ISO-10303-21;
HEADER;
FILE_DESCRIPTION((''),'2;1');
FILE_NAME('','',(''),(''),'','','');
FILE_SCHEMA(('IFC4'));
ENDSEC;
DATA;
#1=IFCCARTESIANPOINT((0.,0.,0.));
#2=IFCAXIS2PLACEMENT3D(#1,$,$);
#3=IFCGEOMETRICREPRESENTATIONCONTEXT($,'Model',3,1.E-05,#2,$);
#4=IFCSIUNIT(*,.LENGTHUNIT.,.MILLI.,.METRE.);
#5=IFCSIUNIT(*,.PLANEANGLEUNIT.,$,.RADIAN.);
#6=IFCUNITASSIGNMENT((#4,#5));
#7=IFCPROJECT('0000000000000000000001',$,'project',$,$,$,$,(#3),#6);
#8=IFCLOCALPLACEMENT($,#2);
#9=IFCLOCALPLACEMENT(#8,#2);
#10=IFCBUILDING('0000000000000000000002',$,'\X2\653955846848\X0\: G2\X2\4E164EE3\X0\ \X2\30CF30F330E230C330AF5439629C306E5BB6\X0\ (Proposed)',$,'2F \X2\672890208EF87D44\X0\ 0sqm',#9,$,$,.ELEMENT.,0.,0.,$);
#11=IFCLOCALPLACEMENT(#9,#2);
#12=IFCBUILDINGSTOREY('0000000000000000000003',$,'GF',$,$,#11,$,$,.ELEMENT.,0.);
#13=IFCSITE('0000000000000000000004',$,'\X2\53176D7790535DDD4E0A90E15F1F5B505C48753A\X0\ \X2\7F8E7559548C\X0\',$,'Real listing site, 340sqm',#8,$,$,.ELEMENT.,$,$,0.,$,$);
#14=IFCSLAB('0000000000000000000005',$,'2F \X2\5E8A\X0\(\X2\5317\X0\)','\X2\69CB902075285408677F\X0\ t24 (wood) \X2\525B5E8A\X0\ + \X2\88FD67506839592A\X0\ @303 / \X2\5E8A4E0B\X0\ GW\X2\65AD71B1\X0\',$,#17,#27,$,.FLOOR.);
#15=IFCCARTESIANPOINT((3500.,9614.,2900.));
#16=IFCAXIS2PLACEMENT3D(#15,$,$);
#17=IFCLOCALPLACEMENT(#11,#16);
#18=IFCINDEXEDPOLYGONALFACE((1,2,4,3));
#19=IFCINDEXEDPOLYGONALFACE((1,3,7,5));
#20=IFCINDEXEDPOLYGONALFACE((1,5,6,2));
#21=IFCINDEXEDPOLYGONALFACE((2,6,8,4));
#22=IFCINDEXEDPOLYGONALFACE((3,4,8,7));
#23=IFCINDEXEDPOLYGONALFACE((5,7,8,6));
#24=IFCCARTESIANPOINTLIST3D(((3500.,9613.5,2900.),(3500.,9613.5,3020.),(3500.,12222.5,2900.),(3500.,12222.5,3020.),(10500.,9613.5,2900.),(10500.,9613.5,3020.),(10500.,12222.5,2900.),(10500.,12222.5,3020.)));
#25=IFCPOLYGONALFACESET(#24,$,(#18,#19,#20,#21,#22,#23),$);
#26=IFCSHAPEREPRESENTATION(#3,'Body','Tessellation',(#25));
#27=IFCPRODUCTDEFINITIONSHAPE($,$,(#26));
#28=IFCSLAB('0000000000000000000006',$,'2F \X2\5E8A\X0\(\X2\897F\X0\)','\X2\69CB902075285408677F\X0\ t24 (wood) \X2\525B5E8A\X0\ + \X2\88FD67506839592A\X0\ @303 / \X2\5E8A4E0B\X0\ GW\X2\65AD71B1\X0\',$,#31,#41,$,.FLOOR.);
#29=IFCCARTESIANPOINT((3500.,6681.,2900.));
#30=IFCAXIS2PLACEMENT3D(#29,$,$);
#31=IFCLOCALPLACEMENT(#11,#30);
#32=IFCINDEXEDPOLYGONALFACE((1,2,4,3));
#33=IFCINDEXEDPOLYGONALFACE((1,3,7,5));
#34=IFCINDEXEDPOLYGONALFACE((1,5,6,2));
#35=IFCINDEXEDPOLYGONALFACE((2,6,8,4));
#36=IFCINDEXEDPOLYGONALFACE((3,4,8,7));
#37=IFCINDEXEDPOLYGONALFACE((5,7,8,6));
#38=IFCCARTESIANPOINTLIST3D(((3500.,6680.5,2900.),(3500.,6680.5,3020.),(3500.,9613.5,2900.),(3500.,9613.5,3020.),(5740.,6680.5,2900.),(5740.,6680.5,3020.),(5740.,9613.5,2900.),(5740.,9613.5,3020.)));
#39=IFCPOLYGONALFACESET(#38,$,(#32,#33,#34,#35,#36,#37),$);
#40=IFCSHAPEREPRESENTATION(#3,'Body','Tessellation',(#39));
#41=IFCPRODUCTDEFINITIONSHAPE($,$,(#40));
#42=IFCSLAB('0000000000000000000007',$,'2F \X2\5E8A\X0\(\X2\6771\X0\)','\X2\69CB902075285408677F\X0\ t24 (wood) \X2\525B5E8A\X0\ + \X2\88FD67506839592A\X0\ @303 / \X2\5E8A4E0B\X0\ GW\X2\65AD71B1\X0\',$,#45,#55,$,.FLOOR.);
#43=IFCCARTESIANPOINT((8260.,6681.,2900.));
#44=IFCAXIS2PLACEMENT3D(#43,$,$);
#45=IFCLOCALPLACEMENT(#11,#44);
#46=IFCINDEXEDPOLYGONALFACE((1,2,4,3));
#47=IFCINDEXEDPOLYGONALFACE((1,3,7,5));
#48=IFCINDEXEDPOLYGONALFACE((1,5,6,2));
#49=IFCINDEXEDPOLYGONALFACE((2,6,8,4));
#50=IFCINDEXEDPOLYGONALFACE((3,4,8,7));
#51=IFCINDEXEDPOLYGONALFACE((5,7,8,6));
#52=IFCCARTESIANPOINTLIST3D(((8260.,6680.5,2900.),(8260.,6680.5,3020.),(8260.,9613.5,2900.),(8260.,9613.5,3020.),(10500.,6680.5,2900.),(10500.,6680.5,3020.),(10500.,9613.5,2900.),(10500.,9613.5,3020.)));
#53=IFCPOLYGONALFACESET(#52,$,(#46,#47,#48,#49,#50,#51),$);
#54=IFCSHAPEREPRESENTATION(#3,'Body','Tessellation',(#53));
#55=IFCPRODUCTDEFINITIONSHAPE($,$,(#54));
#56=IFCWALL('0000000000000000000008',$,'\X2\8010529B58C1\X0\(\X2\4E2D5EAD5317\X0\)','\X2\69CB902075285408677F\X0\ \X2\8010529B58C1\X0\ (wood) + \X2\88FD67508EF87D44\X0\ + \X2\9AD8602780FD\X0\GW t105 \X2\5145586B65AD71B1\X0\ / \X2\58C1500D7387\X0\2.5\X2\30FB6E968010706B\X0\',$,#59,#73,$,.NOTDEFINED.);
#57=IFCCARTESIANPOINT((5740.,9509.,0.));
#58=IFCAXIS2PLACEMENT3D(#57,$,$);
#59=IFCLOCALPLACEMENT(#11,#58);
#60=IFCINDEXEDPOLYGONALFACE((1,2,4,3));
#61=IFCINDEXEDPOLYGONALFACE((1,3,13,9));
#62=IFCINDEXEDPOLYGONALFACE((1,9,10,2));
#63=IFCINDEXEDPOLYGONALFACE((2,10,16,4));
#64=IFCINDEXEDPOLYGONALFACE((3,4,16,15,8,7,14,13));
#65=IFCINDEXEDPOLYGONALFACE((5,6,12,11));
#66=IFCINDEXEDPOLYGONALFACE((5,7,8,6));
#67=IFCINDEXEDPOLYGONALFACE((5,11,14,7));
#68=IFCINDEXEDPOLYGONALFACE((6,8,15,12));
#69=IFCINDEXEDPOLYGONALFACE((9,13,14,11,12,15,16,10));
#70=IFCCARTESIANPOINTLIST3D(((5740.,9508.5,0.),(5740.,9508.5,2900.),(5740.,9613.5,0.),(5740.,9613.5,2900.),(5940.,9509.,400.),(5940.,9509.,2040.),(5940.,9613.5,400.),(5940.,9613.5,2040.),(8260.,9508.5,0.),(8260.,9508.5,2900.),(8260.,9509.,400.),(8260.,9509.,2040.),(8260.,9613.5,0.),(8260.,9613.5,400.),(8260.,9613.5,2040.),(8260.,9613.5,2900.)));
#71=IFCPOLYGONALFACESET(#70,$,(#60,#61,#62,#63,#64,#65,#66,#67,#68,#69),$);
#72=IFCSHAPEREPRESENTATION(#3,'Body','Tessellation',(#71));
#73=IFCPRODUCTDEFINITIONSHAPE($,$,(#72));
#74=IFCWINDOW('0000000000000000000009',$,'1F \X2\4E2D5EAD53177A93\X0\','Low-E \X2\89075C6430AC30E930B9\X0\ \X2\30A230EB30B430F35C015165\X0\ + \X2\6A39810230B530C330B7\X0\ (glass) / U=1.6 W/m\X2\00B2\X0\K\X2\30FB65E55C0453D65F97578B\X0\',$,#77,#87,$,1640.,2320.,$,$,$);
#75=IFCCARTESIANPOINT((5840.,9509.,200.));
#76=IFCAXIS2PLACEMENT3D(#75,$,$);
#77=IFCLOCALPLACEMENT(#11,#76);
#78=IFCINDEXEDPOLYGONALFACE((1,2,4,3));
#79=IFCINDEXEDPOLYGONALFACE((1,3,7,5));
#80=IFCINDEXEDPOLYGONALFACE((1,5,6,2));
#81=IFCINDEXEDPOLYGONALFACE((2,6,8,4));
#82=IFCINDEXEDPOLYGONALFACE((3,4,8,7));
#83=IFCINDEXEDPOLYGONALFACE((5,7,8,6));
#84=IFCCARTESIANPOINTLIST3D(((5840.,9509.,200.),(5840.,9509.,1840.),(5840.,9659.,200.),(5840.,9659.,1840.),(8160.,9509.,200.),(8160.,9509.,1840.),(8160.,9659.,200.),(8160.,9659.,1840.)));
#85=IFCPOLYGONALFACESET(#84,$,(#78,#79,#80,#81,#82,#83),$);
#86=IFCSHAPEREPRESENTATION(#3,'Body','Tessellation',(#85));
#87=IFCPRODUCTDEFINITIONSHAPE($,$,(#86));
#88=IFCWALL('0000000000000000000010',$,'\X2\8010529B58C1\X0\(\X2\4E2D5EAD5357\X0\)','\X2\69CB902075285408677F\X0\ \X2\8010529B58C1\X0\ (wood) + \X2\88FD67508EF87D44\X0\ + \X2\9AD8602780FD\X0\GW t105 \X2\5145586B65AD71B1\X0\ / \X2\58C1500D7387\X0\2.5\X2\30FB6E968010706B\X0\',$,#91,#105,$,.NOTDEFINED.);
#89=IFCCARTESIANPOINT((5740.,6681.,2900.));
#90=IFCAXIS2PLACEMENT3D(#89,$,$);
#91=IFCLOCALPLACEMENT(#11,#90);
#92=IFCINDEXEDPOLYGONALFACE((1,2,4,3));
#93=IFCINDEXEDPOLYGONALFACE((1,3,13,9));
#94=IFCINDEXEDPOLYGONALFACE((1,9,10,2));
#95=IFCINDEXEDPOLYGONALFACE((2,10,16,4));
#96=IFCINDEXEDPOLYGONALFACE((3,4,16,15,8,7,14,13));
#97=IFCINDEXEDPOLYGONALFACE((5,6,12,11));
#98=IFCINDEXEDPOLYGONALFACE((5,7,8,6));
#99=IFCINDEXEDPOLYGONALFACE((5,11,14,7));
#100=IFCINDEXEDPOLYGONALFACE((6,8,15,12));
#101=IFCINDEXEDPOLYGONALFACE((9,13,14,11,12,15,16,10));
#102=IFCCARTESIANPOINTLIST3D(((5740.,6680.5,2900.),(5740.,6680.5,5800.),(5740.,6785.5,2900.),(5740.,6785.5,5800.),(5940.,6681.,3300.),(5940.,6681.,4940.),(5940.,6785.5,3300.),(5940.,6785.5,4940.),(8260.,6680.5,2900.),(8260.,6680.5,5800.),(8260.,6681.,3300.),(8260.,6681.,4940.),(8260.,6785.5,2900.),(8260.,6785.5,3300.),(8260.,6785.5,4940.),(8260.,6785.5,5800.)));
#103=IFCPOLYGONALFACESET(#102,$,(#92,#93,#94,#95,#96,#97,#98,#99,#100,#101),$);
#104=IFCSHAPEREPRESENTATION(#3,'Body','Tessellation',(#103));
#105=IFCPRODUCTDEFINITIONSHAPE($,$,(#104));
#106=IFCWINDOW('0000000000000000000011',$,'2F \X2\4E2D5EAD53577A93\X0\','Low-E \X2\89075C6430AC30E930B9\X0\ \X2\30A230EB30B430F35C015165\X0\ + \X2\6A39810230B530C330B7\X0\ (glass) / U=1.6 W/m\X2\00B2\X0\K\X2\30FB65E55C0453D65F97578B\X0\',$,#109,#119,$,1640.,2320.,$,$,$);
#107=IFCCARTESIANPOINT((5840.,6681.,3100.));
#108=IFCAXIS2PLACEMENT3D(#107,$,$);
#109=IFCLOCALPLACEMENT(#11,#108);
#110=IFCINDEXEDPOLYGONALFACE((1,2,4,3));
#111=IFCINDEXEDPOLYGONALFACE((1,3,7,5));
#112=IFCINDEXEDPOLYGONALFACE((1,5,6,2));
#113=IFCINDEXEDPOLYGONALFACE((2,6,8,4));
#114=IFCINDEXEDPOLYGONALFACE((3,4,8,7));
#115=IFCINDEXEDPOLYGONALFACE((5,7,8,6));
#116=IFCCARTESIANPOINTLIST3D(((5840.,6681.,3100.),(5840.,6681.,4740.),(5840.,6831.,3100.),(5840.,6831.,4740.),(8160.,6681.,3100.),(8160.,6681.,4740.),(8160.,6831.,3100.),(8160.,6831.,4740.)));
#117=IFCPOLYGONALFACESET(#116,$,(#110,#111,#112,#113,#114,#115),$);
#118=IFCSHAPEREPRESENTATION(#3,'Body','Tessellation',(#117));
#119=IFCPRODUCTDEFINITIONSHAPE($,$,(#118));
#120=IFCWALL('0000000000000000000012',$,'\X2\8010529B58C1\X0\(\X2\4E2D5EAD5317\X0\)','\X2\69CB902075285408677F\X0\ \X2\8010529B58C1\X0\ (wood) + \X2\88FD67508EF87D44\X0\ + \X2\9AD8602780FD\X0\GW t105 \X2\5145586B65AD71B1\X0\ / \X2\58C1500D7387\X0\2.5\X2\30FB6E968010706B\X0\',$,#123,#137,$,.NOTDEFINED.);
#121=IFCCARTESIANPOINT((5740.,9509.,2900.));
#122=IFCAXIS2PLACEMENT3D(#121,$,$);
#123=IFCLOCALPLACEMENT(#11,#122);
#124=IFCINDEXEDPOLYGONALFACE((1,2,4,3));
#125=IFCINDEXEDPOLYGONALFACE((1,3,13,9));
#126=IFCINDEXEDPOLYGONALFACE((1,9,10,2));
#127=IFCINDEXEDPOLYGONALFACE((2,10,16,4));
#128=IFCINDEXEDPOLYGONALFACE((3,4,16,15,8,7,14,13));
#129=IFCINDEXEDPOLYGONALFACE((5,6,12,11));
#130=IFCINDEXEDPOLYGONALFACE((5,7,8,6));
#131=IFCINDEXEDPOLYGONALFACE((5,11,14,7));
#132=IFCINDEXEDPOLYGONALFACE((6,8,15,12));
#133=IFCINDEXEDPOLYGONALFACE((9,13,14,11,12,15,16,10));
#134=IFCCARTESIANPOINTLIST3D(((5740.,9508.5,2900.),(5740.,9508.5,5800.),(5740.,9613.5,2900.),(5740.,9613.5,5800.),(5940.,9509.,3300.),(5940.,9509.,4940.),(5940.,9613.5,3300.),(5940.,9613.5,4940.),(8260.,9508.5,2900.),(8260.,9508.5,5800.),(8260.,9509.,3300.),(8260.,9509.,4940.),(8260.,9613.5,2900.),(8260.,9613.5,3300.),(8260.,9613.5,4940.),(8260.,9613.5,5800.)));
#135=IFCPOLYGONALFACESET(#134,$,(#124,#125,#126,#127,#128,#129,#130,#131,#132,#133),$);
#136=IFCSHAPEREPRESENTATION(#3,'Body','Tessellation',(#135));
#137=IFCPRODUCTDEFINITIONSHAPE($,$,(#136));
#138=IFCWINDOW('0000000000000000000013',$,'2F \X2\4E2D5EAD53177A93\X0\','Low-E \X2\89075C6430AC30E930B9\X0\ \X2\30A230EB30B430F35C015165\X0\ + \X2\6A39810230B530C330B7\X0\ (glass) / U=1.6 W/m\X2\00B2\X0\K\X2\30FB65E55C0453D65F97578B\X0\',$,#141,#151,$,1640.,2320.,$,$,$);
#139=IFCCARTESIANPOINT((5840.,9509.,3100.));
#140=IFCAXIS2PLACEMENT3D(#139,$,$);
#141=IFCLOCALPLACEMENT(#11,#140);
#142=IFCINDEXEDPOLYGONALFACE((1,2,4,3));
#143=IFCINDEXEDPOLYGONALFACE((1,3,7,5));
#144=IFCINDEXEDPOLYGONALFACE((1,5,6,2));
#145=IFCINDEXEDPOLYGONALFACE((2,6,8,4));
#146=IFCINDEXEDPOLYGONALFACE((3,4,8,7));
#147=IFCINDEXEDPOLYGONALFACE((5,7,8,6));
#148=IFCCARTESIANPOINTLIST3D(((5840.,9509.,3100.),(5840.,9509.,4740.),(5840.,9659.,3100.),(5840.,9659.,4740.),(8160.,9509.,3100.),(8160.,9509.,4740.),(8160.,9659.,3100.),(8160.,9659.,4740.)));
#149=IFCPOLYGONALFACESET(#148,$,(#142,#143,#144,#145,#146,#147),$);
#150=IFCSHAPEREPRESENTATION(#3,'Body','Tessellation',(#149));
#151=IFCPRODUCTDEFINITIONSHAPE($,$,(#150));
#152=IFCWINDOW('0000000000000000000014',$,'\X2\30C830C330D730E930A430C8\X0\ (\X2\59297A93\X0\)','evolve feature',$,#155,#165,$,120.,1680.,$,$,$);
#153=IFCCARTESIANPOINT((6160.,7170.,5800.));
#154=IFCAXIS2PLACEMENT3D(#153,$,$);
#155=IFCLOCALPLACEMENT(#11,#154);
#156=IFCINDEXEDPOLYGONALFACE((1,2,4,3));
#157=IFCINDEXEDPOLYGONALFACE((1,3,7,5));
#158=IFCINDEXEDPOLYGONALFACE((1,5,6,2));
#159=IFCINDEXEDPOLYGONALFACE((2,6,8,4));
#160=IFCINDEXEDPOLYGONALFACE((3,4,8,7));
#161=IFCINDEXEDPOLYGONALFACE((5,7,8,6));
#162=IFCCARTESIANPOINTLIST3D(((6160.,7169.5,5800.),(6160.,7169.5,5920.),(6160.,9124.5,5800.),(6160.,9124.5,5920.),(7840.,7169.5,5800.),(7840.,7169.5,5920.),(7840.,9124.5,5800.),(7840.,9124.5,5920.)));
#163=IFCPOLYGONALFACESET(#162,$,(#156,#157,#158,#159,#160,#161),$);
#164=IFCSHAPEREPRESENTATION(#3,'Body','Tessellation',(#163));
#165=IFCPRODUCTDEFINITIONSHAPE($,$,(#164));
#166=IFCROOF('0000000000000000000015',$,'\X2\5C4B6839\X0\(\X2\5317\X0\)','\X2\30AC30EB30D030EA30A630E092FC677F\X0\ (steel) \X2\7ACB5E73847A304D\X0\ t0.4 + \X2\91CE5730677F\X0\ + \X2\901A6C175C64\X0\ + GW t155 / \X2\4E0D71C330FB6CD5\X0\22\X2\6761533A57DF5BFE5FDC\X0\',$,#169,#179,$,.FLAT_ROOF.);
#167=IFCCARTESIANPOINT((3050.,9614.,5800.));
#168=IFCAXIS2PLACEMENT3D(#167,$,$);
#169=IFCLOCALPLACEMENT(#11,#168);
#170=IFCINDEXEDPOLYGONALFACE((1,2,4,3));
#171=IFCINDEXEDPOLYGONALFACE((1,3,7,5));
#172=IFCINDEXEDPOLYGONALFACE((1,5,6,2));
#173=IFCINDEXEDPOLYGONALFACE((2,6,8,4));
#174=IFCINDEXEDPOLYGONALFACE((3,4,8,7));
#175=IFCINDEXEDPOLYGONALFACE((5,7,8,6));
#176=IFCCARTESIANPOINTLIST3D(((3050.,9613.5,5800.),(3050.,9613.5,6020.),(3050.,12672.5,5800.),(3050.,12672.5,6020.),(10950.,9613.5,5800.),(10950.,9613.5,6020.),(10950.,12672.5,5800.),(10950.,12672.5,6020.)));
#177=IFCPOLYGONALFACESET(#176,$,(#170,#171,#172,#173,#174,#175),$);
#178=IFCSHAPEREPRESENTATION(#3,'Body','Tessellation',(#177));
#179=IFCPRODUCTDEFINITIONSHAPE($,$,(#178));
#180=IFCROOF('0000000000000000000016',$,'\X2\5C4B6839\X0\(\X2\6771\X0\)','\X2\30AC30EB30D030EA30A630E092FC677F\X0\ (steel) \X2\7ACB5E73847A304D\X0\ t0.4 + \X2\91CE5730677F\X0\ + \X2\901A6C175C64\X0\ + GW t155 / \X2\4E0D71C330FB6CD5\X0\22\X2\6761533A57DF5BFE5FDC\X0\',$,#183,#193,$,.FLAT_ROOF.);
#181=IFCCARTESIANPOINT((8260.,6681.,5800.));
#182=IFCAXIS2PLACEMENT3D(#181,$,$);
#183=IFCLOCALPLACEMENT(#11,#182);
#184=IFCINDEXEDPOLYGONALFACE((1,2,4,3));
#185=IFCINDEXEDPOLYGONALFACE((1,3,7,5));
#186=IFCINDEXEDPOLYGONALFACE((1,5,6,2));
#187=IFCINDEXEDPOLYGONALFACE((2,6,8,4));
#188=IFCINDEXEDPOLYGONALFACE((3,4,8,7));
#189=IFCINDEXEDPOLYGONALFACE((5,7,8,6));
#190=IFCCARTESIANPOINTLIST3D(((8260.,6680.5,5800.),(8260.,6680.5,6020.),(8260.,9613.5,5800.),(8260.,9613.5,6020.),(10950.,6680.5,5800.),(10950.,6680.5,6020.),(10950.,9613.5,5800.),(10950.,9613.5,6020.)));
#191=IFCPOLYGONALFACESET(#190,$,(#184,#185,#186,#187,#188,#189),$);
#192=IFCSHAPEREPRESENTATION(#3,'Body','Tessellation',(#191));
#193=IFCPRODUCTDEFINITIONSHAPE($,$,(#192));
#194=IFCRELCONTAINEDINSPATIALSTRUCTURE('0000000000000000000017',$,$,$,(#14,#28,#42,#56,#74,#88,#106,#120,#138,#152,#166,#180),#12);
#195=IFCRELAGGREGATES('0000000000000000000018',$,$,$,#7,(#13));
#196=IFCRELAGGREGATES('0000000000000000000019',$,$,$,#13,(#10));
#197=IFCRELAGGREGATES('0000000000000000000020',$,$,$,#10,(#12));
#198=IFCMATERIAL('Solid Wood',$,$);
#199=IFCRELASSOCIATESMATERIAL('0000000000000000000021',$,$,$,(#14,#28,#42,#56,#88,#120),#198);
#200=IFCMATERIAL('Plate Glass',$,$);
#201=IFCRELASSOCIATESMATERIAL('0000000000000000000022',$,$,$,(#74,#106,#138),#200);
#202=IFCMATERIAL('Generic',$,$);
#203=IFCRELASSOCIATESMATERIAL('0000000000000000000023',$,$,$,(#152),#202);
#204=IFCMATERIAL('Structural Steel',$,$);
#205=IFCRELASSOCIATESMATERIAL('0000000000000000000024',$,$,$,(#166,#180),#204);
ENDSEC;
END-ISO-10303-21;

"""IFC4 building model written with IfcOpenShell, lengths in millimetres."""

from ifc_helpers import new_model, si_unit, frame, frame_2d, origin, place, context, project, spatial, rectangle, extrude, material, element, fill, save


model = new_model("IFC4")

# Units and contexts
model_context = context("Model", 3, precision=1e-05, world=origin())
ifc_project = project(units=[si_unit("LENGTHUNIT", "METRE", prefix="MILLI"), si_unit("PLANEANGLEUNIT", "RADIAN")], contexts=[model_context])

# Site, building, storey
site_placement = place(None, origin())
site = spatial("IfcSite", under=ifc_project, at=site_placement, Name="北海道川上郡弟子屈町 美留和", ObjectType="Real listing site, 340sqm", CompositionType="ELEMENT", RefElevation=0.0)
building_placement = place(site_placement, origin())
building = spatial("IfcBuilding", under=site, at=building_placement, Name="改善案: G2世代 ハンモック吹抜の家 (Proposed)", ObjectType="2F 木造軸組 0sqm", CompositionType="ELEMENT", ElevationOfRefHeight=0.0, ElevationOfTerrain=0.0)
storey_placement = place(building_placement, origin())
storey = spatial("IfcBuildingStorey", under=building, at=storey_placement, Name="GF", CompositionType="ELEMENT", Elevation=0.0)

# Slabs
ifc_material_1 = material(Name="Solid Wood")
slab_1_placement = place(storey_placement, frame((3500.0, 9614.0, 2900.0)))
element("IfcSlab", 1, at=slab_1_placement, inside=storey, material=ifc_material_1, Name="2F 床(北)", Description="構造用合板 t24 (wood) 剛床 + 製材根太 @303 / 床下 GW断熱", PredefinedType="FLOOR", context=model_context, shape_type="SweptSolid", body=[
    extrude(rectangle(XDim=7000.0, YDim=2609.0, at=frame_2d((3500.0, 1304.0))), frame((3500.0, 9614.0, 2900.0)), (0.0, 0.0, 1.0), 120.0),
])
slab_2_placement = place(storey_placement, frame((3500.0, 6681.0, 2900.0)))
element("IfcSlab", 2, at=slab_2_placement, inside=storey, material=ifc_material_1, Name="2F 床(西)", Description="構造用合板 t24 (wood) 剛床 + 製材根太 @303 / 床下 GW断熱", PredefinedType="FLOOR", context=model_context, shape_type="SweptSolid", body=[
    extrude(rectangle(XDim=2240.0, YDim=2933.0, at=frame_2d((1120.0, 1466.0))), frame((3500.0, 6681.0, 2900.0)), (0.0, 0.0, 1.0), 120.0),
])
slab_3_placement = place(storey_placement, frame((8260.0, 6681.0, 2900.0)))
element("IfcSlab", 3, at=slab_3_placement, inside=storey, material=ifc_material_1, Name="2F 床(東)", Description="構造用合板 t24 (wood) 剛床 + 製材根太 @303 / 床下 GW断熱", PredefinedType="FLOOR", context=model_context, shape_type="SweptSolid", body=[
    extrude(rectangle(XDim=2240.0, YDim=2933.0, at=frame_2d((1120.0, 1466.0))), frame((8260.0, 6681.0, 2900.0)), (0.0, 0.0, 1.0), 120.0),
])

# Wall, opening, window
wall_1_placement = place(storey_placement, frame((5740.0, 9509.0, 0.0)))
wall_1 = element("IfcWall", 4, at=wall_1_placement, inside=storey, material=ifc_material_1, Name="耐力壁(中庭北)", Description="構造用合板 耐力壁 (wood) + 製材軸組 + 高性能GW t105 充填断熱 / 壁倍率2.5・準耐火", PredefinedType="NOTDEFINED", context=model_context, shape_type="SweptSolid", body=[
    extrude(rectangle(XDim=2520.0, YDim=105.0, at=frame_2d((1260.0, 52.0))), frame((5740.0, 9509.0, 0.0)), (0.0, 0.0, 1.0), 2900.0),
])
opening_1_placement = place(storey_placement, frame((5840.0, 9509.0, 200.0)))
opening_1 = element("IfcOpeningElement", 5, at=opening_1_placement, cuts=wall_1, PredefinedType="NOTDEFINED", context=model_context, shape_type="SweptSolid", body=[
    extrude(rectangle(XDim=2320.0, YDim=150.0, at=frame_2d((1160.0, 75.0))), frame((5840.0, 9509.0, 200.0)), (0.0, 0.0, 1.0), 1640.0),
])
ifc_material_2 = material(Name="Plate Glass")
window_1_placement = place(storey_placement, frame((5840.0, 9509.0, 200.0)))
window_1 = element("IfcWindow", 6, at=window_1_placement, inside=storey, material=ifc_material_2, Name="1F 中庭北窓", Description="Low-E 複層ガラス アルゴン封入 + 樹脂サッシ (glass) / U=1.6 W/m²K・日射取得型", OverallHeight=1640.0, OverallWidth=2320.0, context=model_context, shape_type="SweptSolid", body=[
    extrude(rectangle(XDim=2320.0, YDim=150.0, at=frame_2d((1160.0, 75.0))), frame((5840.0, 9509.0, 200.0)), (0.0, 0.0, 1.0), 1640.0),
])
fill(opening_1, window_1)

# Walls, openings, windows
wall_2_placement = place(storey_placement, frame((5740.0, 6681.0, 2900.0)))
wall_2 = element("IfcWall", 7, at=wall_2_placement, inside=storey, material=ifc_material_1, Name="耐力壁(中庭南)", Description="構造用合板 耐力壁 (wood) + 製材軸組 + 高性能GW t105 充填断熱 / 壁倍率2.5・準耐火", PredefinedType="NOTDEFINED", context=model_context, shape_type="SweptSolid", body=[
    extrude(rectangle(XDim=2520.0, YDim=105.0, at=frame_2d((1260.0, 52.0))), frame((5740.0, 6681.0, 2900.0)), (0.0, 0.0, 1.0), 2900.0),
])
opening_2_placement = place(storey_placement, frame((5840.0, 6681.0, 3100.0)))
opening_2 = element("IfcOpeningElement", 8, at=opening_2_placement, cuts=wall_2, PredefinedType="NOTDEFINED", context=model_context, shape_type="SweptSolid", body=[
    extrude(rectangle(XDim=2320.0, YDim=150.0, at=frame_2d((1160.0, 75.0))), frame((5840.0, 6681.0, 3100.0)), (0.0, 0.0, 1.0), 1640.0),
])
window_2_placement = place(storey_placement, frame((5840.0, 6681.0, 3100.0)))
window_2 = element("IfcWindow", 9, at=window_2_placement, inside=storey, material=ifc_material_2, Name="2F 中庭南窓", Description="Low-E 複層ガラス アルゴン封入 + 樹脂サッシ (glass) / U=1.6 W/m²K・日射取得型", OverallHeight=1640.0, OverallWidth=2320.0, context=model_context, shape_type="SweptSolid", body=[
    extrude(rectangle(XDim=2320.0, YDim=150.0, at=frame_2d((1160.0, 75.0))), frame((5840.0, 6681.0, 3100.0)), (0.0, 0.0, 1.0), 1640.0),
])
fill(opening_2, window_2)
wall_3_placement = place(storey_placement, frame((5740.0, 9509.0, 2900.0)))
wall_3 = element("IfcWall", 10, at=wall_3_placement, inside=storey, material=ifc_material_1, Name="耐力壁(中庭北)", Description="構造用合板 耐力壁 (wood) + 製材軸組 + 高性能GW t105 充填断熱 / 壁倍率2.5・準耐火", PredefinedType="NOTDEFINED", context=model_context, shape_type="SweptSolid", body=[
    extrude(rectangle(XDim=2520.0, YDim=105.0, at=frame_2d((1260.0, 52.0))), frame((5740.0, 9509.0, 2900.0)), (0.0, 0.0, 1.0), 2900.0),
])
opening_3_placement = place(storey_placement, frame((5840.0, 9509.0, 3100.0)))
opening_3 = element("IfcOpeningElement", 11, at=opening_3_placement, cuts=wall_3, PredefinedType="NOTDEFINED", context=model_context, shape_type="SweptSolid", body=[
    extrude(rectangle(XDim=2320.0, YDim=150.0, at=frame_2d((1160.0, 75.0))), frame((5840.0, 9509.0, 3100.0)), (0.0, 0.0, 1.0), 1640.0),
])
window_3_placement = place(storey_placement, frame((5840.0, 9509.0, 3100.0)))
window_3 = element("IfcWindow", 12, at=window_3_placement, inside=storey, material=ifc_material_2, Name="2F 中庭北窓", Description="Low-E 複層ガラス アルゴン封入 + 樹脂サッシ (glass) / U=1.6 W/m²K・日射取得型", OverallHeight=1640.0, OverallWidth=2320.0, context=model_context, shape_type="SweptSolid", body=[
    extrude(rectangle(XDim=2320.0, YDim=150.0, at=frame_2d((1160.0, 75.0))), frame((5840.0, 9509.0, 3100.0)), (0.0, 0.0, 1.0), 1640.0),
])
fill(opening_3, window_3)

# Window
ifc_material_3 = material(Name="Generic")
window_4_placement = place(storey_placement, frame((6160.0, 7170.0, 5800.0)))
element("IfcWindow", 13, at=window_4_placement, inside=storey, material=ifc_material_3, Name="トップライト (天窓)", Description="evolve feature", OverallHeight=120.0, OverallWidth=1680.0, context=model_context, shape_type="SweptSolid", body=[
    extrude(rectangle(XDim=1680.0, YDim=1955.0, at=frame_2d((840.0, 977.0))), frame((6160.0, 7170.0, 5800.0)), (0.0, 0.0, 1.0), 120.0),
])

# Roofs
ifc_material_4 = material(Name="Structural Steel")
roof_1_placement = place(storey_placement, frame((3050.0, 9614.0, 5800.0)))
element("IfcRoof", 14, at=roof_1_placement, inside=storey, material=ifc_material_4, Name="屋根(北)", Description="ガルバリウム鋼板 (steel) 立平葺き t0.4 + 野地板 + 通気層 + GW t155 / 不燃・法22条区域対応", PredefinedType="FLAT_ROOF", context=model_context, shape_type="SweptSolid", body=[
    extrude(rectangle(XDim=7900.0, YDim=3059.0, at=frame_2d((3950.0, 1529.0))), frame((3050.0, 9614.0, 5800.0)), (0.0, 0.0, 1.0), 220.0),
])
roof_2_placement = place(storey_placement, frame((8260.0, 6681.0, 5800.0)))
element("IfcRoof", 15, at=roof_2_placement, inside=storey, material=ifc_material_4, Name="屋根(東)", Description="ガルバリウム鋼板 (steel) 立平葺き t0.4 + 野地板 + 通気層 + GW t155 / 不燃・法22条区域対応", PredefinedType="FLAT_ROOF", context=model_context, shape_type="SweptSolid", body=[
    extrude(rectangle(XDim=2690.0, YDim=2933.0, at=frame_2d((1345.0, 1466.0))), frame((8260.0, 6681.0, 5800.0)), (0.0, 0.0, 1.0), 220.0),
])

save(model, "model.ifc")
